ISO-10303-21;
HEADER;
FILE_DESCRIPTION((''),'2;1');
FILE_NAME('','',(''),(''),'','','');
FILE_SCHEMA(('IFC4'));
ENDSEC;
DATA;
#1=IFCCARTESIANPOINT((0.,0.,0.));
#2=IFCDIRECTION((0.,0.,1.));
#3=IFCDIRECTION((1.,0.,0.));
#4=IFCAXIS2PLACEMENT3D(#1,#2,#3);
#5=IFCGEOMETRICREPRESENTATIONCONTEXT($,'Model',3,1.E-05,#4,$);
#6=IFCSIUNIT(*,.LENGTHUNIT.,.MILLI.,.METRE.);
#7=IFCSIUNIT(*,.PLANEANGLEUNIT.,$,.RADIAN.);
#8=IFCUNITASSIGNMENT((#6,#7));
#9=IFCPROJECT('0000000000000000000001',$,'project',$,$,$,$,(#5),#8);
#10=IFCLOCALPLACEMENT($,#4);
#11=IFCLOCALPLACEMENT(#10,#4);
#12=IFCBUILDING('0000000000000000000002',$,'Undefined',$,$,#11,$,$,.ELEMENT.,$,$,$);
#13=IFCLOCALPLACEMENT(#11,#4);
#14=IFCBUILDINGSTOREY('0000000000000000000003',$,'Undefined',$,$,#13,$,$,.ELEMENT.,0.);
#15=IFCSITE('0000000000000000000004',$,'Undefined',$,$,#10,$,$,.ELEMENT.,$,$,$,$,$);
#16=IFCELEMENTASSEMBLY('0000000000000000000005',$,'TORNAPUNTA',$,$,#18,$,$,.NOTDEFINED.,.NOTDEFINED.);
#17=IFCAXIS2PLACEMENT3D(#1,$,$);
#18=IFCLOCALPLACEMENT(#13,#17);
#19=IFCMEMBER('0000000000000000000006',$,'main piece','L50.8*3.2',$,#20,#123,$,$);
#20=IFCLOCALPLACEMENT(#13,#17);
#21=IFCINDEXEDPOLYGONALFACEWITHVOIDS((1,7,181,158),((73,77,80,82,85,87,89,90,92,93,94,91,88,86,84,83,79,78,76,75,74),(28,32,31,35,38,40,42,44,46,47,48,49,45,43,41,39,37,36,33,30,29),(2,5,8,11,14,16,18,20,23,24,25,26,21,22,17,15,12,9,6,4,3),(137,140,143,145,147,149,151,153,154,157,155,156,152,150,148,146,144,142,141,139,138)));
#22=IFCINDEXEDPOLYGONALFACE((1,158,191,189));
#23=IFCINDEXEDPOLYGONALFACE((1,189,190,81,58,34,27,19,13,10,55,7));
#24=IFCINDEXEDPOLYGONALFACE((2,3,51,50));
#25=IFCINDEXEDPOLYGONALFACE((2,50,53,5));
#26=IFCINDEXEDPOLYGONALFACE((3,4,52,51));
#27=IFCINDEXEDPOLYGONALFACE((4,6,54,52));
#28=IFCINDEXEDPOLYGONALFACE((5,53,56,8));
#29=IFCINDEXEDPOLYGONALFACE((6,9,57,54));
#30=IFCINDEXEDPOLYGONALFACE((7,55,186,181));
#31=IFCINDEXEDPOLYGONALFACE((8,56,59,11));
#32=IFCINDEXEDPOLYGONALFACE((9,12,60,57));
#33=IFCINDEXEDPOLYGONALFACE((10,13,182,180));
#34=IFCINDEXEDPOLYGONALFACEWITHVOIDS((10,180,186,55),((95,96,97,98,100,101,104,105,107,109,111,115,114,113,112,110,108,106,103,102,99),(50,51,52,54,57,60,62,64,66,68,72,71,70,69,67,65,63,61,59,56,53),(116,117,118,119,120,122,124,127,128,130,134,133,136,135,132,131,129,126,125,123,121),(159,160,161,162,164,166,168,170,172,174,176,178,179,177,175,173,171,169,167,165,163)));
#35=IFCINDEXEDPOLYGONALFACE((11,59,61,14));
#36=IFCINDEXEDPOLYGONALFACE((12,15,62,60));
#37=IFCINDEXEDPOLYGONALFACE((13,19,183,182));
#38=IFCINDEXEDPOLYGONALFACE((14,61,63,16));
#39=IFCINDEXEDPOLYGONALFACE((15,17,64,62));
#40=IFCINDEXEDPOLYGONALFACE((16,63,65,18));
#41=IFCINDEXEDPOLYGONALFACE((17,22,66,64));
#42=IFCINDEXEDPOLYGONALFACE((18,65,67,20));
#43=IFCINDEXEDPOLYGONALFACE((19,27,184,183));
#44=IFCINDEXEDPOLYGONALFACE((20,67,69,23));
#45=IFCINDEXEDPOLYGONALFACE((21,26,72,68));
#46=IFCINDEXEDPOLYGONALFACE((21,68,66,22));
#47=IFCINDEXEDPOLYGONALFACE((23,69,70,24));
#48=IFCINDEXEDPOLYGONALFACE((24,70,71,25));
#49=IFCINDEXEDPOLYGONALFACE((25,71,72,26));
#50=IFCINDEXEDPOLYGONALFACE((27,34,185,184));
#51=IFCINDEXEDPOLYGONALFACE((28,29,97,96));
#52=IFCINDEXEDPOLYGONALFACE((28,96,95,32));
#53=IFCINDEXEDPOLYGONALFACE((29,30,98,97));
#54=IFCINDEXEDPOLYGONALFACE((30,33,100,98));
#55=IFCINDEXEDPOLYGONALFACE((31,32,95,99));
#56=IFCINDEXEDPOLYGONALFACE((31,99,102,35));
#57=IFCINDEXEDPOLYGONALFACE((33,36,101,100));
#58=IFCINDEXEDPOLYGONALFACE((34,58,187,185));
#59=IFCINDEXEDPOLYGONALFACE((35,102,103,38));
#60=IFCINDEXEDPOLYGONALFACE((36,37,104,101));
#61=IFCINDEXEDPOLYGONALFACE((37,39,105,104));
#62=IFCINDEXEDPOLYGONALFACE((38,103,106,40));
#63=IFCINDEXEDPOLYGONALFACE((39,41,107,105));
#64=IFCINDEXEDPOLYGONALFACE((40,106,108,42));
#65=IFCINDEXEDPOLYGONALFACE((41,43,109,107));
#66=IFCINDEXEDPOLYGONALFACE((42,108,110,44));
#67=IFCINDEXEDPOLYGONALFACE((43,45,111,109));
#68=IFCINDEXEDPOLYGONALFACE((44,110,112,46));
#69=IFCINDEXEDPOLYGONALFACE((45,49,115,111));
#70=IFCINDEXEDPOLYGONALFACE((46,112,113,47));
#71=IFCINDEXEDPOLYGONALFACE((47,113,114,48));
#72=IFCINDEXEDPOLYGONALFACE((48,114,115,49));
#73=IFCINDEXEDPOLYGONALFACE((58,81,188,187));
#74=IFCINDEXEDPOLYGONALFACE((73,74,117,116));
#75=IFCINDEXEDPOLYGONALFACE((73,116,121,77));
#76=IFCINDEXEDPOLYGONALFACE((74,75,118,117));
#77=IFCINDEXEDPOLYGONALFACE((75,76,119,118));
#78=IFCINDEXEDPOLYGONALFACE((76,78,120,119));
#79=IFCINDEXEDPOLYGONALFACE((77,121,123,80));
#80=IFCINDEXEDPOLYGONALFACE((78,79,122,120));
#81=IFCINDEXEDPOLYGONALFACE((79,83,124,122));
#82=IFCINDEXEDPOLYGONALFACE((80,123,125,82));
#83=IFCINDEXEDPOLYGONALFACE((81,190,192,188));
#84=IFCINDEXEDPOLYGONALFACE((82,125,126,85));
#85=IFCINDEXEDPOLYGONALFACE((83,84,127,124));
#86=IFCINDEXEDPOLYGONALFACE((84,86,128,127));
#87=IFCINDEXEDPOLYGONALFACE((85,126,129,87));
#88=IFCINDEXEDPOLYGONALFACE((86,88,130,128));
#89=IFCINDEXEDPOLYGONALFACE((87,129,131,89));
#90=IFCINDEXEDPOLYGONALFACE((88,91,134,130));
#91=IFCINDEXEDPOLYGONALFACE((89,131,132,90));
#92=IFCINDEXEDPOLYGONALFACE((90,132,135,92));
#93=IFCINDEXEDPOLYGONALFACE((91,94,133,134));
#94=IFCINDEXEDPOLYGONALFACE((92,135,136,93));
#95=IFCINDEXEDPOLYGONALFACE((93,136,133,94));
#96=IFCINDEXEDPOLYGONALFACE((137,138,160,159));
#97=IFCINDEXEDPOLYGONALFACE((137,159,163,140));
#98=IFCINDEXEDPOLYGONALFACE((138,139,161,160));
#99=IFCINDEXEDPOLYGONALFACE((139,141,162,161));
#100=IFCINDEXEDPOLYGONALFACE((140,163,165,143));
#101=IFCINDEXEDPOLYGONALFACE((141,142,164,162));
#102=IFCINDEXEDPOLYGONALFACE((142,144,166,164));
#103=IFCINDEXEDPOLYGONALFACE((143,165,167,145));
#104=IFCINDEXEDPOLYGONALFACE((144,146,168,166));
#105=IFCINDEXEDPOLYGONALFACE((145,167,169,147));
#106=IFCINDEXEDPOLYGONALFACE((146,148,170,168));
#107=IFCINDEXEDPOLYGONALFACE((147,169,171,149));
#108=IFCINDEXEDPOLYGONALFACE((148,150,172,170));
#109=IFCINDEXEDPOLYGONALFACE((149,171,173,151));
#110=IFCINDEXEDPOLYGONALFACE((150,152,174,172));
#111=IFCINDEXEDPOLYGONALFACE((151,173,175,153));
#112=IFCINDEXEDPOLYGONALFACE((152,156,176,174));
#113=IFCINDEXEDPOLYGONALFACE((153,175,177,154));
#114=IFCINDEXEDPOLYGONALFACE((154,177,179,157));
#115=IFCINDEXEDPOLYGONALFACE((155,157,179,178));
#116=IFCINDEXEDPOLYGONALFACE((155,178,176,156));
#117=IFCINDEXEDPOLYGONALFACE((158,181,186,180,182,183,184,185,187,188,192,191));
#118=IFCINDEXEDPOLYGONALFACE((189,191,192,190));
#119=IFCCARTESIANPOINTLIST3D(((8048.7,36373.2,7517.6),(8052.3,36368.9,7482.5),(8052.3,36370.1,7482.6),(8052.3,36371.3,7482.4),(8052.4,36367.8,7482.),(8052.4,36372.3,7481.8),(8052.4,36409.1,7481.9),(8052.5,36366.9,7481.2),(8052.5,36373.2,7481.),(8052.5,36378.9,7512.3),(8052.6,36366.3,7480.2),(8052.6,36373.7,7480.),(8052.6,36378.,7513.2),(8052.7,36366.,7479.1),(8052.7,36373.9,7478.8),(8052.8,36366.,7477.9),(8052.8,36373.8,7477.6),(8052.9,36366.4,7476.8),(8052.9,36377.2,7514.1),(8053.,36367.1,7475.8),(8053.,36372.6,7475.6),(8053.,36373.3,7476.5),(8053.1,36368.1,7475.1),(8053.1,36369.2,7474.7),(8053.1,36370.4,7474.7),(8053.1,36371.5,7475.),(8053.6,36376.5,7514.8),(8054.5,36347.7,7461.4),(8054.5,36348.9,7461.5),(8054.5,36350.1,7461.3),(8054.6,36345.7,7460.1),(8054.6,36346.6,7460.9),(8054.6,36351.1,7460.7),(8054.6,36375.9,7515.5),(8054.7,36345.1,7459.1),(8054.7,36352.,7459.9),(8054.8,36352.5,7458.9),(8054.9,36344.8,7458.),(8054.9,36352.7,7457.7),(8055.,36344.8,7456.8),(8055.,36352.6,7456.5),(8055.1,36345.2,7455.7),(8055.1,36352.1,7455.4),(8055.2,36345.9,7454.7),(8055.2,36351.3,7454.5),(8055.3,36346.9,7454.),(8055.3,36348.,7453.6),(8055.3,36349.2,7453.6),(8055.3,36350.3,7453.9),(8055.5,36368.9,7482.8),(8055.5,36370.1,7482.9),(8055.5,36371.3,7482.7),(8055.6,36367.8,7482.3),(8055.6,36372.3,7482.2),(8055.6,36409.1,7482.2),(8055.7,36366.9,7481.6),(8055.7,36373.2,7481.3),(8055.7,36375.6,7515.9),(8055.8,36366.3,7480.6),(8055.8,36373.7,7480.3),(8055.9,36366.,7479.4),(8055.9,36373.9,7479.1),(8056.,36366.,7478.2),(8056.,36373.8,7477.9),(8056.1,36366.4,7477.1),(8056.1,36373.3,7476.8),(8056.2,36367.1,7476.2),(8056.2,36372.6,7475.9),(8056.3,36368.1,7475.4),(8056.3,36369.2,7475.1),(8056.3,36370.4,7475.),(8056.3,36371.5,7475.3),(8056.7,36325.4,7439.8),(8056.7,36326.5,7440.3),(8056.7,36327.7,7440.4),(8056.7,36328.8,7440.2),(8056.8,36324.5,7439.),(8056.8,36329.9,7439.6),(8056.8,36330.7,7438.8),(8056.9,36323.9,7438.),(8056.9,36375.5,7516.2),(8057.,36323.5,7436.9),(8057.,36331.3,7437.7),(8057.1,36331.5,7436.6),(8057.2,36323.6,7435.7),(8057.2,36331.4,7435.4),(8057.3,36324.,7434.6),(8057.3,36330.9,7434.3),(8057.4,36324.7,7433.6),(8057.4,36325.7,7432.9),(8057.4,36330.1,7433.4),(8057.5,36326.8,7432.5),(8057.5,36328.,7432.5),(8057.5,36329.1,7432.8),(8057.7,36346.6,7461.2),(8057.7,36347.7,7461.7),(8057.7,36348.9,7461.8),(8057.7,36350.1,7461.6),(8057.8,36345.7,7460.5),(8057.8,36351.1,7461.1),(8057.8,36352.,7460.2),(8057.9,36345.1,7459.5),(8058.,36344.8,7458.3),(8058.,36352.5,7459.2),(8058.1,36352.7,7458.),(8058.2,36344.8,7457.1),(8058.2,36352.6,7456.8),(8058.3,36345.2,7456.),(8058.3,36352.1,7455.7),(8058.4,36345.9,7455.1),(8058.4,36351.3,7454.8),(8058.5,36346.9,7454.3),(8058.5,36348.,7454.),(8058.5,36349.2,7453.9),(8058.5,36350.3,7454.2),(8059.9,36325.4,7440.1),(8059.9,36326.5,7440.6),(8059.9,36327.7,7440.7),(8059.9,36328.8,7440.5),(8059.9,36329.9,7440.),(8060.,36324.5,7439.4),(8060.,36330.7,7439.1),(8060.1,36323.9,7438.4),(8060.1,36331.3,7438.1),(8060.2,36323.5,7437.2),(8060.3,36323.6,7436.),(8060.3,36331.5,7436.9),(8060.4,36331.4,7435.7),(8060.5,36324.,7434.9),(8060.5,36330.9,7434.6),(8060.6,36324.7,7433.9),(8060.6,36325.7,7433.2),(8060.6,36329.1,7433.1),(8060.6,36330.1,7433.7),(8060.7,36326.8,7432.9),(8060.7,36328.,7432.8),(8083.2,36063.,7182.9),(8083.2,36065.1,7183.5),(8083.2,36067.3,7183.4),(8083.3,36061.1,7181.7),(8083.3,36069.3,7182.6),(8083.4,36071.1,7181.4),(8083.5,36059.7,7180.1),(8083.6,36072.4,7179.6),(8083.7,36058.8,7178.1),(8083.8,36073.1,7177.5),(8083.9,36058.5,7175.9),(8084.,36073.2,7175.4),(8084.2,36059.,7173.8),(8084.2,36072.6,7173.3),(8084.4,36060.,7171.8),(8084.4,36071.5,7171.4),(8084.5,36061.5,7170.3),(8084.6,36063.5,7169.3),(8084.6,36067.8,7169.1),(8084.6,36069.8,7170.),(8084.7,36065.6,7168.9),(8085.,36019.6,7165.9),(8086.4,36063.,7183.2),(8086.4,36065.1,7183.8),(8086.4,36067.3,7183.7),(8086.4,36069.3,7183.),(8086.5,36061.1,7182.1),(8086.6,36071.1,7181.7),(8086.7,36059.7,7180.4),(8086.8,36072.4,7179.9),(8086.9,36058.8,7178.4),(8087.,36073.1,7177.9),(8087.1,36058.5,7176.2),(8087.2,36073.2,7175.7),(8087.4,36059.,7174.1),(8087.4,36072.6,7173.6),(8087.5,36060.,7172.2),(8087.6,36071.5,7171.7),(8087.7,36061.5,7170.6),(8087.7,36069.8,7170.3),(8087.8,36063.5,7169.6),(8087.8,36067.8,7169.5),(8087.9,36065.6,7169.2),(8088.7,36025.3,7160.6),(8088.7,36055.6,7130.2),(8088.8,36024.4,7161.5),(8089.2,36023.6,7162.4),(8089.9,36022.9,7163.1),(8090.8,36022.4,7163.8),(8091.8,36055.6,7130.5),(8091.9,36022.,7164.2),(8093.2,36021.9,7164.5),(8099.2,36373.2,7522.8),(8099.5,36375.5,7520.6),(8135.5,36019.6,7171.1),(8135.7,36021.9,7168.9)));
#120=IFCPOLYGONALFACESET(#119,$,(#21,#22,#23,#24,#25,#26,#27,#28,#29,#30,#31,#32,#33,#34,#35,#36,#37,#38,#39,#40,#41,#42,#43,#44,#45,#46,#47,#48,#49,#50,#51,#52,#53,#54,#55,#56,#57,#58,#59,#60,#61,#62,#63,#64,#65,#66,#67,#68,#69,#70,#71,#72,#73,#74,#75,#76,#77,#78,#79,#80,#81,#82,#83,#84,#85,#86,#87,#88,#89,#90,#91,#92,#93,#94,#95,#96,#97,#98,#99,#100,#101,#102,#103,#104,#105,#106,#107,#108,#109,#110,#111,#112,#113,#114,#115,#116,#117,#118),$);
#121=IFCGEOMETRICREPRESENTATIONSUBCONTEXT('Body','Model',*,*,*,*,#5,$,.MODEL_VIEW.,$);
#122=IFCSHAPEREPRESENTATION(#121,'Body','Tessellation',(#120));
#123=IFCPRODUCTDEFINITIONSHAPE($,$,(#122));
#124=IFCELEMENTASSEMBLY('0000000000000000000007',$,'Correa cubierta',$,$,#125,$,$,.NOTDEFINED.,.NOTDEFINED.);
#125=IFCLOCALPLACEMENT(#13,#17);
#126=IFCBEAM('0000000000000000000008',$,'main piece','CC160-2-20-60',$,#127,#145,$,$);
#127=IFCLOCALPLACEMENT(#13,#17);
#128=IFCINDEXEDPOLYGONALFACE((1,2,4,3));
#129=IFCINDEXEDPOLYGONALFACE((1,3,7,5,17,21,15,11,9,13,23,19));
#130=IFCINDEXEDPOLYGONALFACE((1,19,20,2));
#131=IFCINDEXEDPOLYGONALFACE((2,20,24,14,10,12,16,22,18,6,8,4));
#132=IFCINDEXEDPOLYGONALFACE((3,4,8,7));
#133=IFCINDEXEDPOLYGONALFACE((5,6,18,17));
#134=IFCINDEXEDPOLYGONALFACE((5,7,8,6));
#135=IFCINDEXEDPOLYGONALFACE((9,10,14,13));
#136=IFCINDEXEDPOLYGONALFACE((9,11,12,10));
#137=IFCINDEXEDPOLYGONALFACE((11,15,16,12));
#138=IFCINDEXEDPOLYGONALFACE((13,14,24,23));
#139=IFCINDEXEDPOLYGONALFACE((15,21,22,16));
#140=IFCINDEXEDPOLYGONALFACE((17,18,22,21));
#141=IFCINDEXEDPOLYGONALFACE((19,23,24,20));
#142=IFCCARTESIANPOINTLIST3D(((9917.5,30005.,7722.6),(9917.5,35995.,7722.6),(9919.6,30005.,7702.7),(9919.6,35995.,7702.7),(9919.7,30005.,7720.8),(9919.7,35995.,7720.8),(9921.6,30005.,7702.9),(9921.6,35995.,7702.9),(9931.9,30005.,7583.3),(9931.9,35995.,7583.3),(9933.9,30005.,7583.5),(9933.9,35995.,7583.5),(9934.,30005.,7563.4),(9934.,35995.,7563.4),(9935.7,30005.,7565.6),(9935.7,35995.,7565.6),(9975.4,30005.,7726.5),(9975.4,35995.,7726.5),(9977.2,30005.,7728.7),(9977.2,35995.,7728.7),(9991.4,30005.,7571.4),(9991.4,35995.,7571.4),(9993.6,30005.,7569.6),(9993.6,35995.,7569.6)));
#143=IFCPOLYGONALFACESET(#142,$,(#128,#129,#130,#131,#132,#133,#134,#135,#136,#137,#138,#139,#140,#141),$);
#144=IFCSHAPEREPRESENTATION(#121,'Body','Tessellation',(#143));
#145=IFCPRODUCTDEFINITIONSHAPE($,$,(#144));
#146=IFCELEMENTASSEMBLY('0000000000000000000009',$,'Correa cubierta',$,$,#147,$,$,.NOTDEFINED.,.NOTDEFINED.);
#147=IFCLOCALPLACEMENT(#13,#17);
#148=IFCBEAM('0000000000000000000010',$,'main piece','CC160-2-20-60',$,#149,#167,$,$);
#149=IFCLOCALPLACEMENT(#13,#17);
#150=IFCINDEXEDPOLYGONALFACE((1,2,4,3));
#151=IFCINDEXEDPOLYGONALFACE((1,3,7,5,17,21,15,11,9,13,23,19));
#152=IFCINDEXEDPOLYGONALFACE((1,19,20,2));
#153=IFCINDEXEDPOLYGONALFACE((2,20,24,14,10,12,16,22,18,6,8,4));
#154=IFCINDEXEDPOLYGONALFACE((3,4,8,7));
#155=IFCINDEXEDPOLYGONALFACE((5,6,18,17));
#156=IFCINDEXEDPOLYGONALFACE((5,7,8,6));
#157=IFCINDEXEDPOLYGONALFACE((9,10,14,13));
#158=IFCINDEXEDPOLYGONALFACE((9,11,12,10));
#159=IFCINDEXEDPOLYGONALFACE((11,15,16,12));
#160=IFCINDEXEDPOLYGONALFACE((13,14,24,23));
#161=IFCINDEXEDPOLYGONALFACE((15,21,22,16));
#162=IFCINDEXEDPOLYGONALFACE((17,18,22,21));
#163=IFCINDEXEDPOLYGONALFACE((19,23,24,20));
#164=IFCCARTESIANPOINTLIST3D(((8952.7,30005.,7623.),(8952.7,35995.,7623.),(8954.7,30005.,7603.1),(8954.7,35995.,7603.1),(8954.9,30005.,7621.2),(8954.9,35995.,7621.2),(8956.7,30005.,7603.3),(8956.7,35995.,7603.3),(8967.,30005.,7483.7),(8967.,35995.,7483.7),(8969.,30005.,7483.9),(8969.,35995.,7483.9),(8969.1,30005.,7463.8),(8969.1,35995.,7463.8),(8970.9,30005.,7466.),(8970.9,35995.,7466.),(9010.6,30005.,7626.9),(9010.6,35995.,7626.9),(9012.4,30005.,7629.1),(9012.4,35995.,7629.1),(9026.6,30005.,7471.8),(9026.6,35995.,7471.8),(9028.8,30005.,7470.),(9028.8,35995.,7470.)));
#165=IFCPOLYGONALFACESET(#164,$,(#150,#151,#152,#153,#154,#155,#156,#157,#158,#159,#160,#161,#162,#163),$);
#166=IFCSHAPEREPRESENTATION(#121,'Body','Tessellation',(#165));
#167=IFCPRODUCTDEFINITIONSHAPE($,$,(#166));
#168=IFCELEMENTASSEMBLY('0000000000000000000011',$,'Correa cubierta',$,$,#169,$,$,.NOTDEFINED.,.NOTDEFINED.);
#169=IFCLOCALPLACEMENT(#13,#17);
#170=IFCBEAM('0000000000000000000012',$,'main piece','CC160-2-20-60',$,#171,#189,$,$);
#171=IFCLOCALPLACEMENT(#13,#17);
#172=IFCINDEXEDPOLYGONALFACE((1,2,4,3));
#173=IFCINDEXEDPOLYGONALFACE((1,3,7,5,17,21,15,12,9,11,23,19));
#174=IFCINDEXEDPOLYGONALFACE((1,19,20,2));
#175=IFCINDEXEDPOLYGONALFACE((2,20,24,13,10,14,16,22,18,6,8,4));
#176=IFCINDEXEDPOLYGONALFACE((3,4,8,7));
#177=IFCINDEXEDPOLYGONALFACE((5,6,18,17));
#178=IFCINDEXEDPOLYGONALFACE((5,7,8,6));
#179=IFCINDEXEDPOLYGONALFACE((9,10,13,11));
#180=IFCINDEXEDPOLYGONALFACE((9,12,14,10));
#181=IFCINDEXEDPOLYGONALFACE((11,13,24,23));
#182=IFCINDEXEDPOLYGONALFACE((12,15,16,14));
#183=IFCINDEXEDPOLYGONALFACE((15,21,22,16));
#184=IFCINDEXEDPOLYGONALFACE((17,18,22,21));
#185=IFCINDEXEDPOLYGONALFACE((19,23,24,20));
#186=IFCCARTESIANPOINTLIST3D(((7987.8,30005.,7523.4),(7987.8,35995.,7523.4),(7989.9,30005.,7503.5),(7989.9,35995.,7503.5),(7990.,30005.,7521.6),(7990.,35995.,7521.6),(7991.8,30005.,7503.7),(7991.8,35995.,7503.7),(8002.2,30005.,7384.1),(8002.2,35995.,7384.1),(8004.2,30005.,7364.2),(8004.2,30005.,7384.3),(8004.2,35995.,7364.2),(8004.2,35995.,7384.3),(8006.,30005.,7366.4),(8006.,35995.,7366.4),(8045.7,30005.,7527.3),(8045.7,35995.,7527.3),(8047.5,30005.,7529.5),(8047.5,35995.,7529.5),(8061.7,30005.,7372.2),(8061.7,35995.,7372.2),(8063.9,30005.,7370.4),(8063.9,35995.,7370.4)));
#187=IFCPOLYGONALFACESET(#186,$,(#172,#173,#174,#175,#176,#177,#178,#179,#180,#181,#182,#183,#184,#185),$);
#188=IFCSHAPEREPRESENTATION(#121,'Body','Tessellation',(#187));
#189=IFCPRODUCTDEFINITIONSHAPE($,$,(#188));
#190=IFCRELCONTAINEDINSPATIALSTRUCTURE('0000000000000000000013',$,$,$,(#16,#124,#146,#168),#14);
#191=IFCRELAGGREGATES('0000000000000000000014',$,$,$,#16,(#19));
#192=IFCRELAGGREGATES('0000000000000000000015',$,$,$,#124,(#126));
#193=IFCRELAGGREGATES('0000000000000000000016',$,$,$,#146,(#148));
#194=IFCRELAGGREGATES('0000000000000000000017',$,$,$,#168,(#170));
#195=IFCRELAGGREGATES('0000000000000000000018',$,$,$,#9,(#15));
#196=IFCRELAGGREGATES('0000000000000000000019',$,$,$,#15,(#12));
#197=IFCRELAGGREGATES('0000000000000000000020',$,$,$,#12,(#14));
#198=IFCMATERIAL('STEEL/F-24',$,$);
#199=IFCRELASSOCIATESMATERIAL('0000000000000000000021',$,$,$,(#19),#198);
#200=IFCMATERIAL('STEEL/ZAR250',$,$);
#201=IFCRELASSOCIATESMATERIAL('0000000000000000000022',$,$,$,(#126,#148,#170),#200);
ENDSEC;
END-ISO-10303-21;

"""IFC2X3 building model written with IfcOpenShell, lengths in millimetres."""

from ifc_helpers import new_model, si_unit, frame, origin_with_axes, origin_2d_with_axis, place, context, subcontext, project, spatial, circle, l_section, c_section, extrude, source, transform, mapped, material, element, aggregate, save


model = new_model("IFC2X3")

# Units and contexts
model_context = context("Model", 3, precision=1e-05, world=origin_with_axes())
body_context = subcontext(model_context, "Body", "Model", "MODEL_VIEW")
ifc_project = project(units=[si_unit("LENGTHUNIT", "METRE", prefix="MILLI"), si_unit("PLANEANGLEUNIT", "RADIAN")], contexts=[model_context])

# Site, building, storey
site_placement = place(None, origin_with_axes())
site = spatial("IfcSite", under=ifc_project, at=site_placement, Name="Undefined", CompositionType="ELEMENT")
building_placement = place(site_placement, origin_with_axes())
building = spatial("IfcBuilding", under=site, at=building_placement, Name="Undefined", CompositionType="ELEMENT")
storey_placement = place(building_placement, origin_with_axes())
storey = spatial("IfcBuildingStorey", under=building, at=storey_placement, Name="Undefined", CompositionType="ELEMENT", Elevation=0.0)

# Element assembly, member, openings
ifc_material_1 = material(Name="STEEL/F-24")
shared_shape_1 = source(origin_with_axes(), body_context, "Body", "SweptSolid", [
    extrude(circle(Radius=4.0, at=origin_2d_with_axis()), frame((0.0, -3.3, 0.0), z_axis=(0.0, 1.0, 0.0), x_axis=(1.0, 0.0, 0.0)), (0.0, 0.0, 1.0), 3.4),
])
shared_shape_2 = source(origin_with_axes(), body_context, "Body", "SweptSolid", [
    extrude(circle(Radius=7.3, at=origin_2d_with_axis()), frame((0.0, -3.3, 0.0), z_axis=(0.0, 1.0, 0.0), x_axis=(1.0, 0.0, 0.0)), (0.0, 0.0, 1.0), 3.4),
])
assembly_1_placement = place(storey_placement, origin_with_axes())
assembly_1 = element("IfcElementAssembly", 1, at=assembly_1_placement, inside=storey, Name="TORNAPUNTA", AssemblyPlace="NOTDEFINED", PredefinedType="NOTDEFINED")
member_1_placement = place(assembly_1_placement, frame((8112.1, 36037.6, 7150.7), z_axis=(0.994727, 0.0, 0.102562), x_axis=(-0.072522, 0.707107, 0.703378)))
member_1 = element("IfcMember", 2, at=member_1_placement, material=ifc_material_1, Name="main piece", Description="L50.8*3.2", context=body_context, shape_type="SweptSolid", body=[
    extrude(l_section(Depth=50.8, Width=50.8, Thickness=3.2, FilletRadius=4.8, at=origin_2d_with_axis()), frame((500.0, 0.0, 0.0), z_axis=(-1.0, 0.0, 0.0), x_axis=(0.0, -1.0, 0.0)), (0.0, 0.0, 1.0), 500.0),
])
opening_1_placement = place(assembly_1_placement, frame((8052.7, 36369.9, 7478.6), z_axis=(0.072522, 0.707107, -0.703378), x_axis=(0.072522, -0.707107, -0.703378)))
element("IfcOpeningElement", 3, at=opening_1_placement, cuts=member_1, ObjectType="Opening", context=body_context, shape_type="MappedRepresentation", body=[
    mapped(shared_shape_1, transform((0.0, 0.0, 0.0))),
    mapped(shared_shape_1, transform((30.0, 0.0, 0.0))),
    mapped(shared_shape_1, transform((60.0, 0.0, 0.0))),
])
opening_2_placement = place(assembly_1_placement, frame((8083.9, 36065.9, 7176.2), z_axis=(-0.072522, -0.707107, 0.703378), x_axis=(-0.072522, 0.707107, 0.703378)))
element("IfcOpeningElement", 4, at=opening_2_placement, cuts=member_1, ObjectType="Opening", context=body_context, shape_type="MappedRepresentation", body=[
    mapped(shared_shape_2, transform((0.0, 0.0, 0.0))),
])
aggregate(assembly_1, [member_1])

# Element assemblies, beams
assembly_2_placement = place(storey_placement, origin_with_axes())
assembly_2 = element("IfcElementAssembly", 5, at=assembly_2_placement, inside=storey, Name="Correa cubierta", AssemblyPlace="NOTDEFINED", PredefinedType="NOTDEFINED")
ifc_material_2 = material(Name="STEEL/ZAR250")
beam_1_placement = place(assembly_2_placement, frame((9955.6, 35995.0, 7646.1), z_axis=(-0.102562, 0.0, 0.994727), x_axis=(0.0, -1.0, 0.0)))
beam_1 = element("IfcBeam", 6, at=beam_1_placement, material=ifc_material_2, Name="main piece", Description="CC160-2-20-60", context=body_context, shape_type="SweptSolid", body=[
    extrude(c_section(Depth=160.0, Width=60.0, WallThickness=2.0, Girth=20.0, at=origin_2d_with_axis()), frame((5990.0, 0.0, 0.0), z_axis=(-1.0, 0.0, 0.0), x_axis=(0.0, -1.0, 0.0)), (0.0, 0.0, 1.0), 5990.0),
])
aggregate(assembly_2, [beam_1])
assembly_3_placement = place(storey_placement, origin_with_axes())
assembly_3 = element("IfcElementAssembly", 7, at=assembly_3_placement, inside=storey, Name="Correa cubierta", AssemblyPlace="NOTDEFINED", PredefinedType="NOTDEFINED")
beam_2_placement = place(assembly_3_placement, frame((8990.7, 35995.0, 7546.5), z_axis=(-0.102562, 0.0, 0.994727), x_axis=(0.0, -1.0, 0.0)))
beam_2 = element("IfcBeam", 8, at=beam_2_placement, material=ifc_material_2, Name="main piece", Description="CC160-2-20-60", context=body_context, shape_type="SweptSolid", body=[
    extrude(c_section(Depth=160.0, Width=60.0, WallThickness=2.0, Girth=20.0, at=origin_2d_with_axis()), frame((5990.0, 0.0, 0.0), z_axis=(-1.0, 0.0, 0.0), x_axis=(0.0, -1.0, 0.0)), (0.0, 0.0, 1.0), 5990.0),
])
aggregate(assembly_3, [beam_2])
assembly_4_placement = place(storey_placement, origin_with_axes())
assembly_4 = element("IfcElementAssembly", 9, at=assembly_4_placement, inside=storey, Name="Correa cubierta", AssemblyPlace="NOTDEFINED", PredefinedType="NOTDEFINED")
beam_3_placement = place(assembly_4_placement, frame((8025.8, 35995.0, 7446.9), z_axis=(-0.102562, 0.0, 0.994727), x_axis=(0.0, -1.0, 0.0)))
beam_3 = element("IfcBeam", 10, at=beam_3_placement, material=ifc_material_2, Name="main piece", Description="CC160-2-20-60", context=body_context, shape_type="SweptSolid", body=[
    extrude(c_section(Depth=160.0, Width=60.0, WallThickness=2.0, Girth=20.0, at=origin_2d_with_axis()), frame((5990.0, 0.0, 0.0), z_axis=(-1.0, 0.0, 0.0), x_axis=(0.0, -1.0, 0.0)), (0.0, 0.0, 1.0), 5990.0),
])
aggregate(assembly_4, [beam_3])

save(model, "model.ifc")
